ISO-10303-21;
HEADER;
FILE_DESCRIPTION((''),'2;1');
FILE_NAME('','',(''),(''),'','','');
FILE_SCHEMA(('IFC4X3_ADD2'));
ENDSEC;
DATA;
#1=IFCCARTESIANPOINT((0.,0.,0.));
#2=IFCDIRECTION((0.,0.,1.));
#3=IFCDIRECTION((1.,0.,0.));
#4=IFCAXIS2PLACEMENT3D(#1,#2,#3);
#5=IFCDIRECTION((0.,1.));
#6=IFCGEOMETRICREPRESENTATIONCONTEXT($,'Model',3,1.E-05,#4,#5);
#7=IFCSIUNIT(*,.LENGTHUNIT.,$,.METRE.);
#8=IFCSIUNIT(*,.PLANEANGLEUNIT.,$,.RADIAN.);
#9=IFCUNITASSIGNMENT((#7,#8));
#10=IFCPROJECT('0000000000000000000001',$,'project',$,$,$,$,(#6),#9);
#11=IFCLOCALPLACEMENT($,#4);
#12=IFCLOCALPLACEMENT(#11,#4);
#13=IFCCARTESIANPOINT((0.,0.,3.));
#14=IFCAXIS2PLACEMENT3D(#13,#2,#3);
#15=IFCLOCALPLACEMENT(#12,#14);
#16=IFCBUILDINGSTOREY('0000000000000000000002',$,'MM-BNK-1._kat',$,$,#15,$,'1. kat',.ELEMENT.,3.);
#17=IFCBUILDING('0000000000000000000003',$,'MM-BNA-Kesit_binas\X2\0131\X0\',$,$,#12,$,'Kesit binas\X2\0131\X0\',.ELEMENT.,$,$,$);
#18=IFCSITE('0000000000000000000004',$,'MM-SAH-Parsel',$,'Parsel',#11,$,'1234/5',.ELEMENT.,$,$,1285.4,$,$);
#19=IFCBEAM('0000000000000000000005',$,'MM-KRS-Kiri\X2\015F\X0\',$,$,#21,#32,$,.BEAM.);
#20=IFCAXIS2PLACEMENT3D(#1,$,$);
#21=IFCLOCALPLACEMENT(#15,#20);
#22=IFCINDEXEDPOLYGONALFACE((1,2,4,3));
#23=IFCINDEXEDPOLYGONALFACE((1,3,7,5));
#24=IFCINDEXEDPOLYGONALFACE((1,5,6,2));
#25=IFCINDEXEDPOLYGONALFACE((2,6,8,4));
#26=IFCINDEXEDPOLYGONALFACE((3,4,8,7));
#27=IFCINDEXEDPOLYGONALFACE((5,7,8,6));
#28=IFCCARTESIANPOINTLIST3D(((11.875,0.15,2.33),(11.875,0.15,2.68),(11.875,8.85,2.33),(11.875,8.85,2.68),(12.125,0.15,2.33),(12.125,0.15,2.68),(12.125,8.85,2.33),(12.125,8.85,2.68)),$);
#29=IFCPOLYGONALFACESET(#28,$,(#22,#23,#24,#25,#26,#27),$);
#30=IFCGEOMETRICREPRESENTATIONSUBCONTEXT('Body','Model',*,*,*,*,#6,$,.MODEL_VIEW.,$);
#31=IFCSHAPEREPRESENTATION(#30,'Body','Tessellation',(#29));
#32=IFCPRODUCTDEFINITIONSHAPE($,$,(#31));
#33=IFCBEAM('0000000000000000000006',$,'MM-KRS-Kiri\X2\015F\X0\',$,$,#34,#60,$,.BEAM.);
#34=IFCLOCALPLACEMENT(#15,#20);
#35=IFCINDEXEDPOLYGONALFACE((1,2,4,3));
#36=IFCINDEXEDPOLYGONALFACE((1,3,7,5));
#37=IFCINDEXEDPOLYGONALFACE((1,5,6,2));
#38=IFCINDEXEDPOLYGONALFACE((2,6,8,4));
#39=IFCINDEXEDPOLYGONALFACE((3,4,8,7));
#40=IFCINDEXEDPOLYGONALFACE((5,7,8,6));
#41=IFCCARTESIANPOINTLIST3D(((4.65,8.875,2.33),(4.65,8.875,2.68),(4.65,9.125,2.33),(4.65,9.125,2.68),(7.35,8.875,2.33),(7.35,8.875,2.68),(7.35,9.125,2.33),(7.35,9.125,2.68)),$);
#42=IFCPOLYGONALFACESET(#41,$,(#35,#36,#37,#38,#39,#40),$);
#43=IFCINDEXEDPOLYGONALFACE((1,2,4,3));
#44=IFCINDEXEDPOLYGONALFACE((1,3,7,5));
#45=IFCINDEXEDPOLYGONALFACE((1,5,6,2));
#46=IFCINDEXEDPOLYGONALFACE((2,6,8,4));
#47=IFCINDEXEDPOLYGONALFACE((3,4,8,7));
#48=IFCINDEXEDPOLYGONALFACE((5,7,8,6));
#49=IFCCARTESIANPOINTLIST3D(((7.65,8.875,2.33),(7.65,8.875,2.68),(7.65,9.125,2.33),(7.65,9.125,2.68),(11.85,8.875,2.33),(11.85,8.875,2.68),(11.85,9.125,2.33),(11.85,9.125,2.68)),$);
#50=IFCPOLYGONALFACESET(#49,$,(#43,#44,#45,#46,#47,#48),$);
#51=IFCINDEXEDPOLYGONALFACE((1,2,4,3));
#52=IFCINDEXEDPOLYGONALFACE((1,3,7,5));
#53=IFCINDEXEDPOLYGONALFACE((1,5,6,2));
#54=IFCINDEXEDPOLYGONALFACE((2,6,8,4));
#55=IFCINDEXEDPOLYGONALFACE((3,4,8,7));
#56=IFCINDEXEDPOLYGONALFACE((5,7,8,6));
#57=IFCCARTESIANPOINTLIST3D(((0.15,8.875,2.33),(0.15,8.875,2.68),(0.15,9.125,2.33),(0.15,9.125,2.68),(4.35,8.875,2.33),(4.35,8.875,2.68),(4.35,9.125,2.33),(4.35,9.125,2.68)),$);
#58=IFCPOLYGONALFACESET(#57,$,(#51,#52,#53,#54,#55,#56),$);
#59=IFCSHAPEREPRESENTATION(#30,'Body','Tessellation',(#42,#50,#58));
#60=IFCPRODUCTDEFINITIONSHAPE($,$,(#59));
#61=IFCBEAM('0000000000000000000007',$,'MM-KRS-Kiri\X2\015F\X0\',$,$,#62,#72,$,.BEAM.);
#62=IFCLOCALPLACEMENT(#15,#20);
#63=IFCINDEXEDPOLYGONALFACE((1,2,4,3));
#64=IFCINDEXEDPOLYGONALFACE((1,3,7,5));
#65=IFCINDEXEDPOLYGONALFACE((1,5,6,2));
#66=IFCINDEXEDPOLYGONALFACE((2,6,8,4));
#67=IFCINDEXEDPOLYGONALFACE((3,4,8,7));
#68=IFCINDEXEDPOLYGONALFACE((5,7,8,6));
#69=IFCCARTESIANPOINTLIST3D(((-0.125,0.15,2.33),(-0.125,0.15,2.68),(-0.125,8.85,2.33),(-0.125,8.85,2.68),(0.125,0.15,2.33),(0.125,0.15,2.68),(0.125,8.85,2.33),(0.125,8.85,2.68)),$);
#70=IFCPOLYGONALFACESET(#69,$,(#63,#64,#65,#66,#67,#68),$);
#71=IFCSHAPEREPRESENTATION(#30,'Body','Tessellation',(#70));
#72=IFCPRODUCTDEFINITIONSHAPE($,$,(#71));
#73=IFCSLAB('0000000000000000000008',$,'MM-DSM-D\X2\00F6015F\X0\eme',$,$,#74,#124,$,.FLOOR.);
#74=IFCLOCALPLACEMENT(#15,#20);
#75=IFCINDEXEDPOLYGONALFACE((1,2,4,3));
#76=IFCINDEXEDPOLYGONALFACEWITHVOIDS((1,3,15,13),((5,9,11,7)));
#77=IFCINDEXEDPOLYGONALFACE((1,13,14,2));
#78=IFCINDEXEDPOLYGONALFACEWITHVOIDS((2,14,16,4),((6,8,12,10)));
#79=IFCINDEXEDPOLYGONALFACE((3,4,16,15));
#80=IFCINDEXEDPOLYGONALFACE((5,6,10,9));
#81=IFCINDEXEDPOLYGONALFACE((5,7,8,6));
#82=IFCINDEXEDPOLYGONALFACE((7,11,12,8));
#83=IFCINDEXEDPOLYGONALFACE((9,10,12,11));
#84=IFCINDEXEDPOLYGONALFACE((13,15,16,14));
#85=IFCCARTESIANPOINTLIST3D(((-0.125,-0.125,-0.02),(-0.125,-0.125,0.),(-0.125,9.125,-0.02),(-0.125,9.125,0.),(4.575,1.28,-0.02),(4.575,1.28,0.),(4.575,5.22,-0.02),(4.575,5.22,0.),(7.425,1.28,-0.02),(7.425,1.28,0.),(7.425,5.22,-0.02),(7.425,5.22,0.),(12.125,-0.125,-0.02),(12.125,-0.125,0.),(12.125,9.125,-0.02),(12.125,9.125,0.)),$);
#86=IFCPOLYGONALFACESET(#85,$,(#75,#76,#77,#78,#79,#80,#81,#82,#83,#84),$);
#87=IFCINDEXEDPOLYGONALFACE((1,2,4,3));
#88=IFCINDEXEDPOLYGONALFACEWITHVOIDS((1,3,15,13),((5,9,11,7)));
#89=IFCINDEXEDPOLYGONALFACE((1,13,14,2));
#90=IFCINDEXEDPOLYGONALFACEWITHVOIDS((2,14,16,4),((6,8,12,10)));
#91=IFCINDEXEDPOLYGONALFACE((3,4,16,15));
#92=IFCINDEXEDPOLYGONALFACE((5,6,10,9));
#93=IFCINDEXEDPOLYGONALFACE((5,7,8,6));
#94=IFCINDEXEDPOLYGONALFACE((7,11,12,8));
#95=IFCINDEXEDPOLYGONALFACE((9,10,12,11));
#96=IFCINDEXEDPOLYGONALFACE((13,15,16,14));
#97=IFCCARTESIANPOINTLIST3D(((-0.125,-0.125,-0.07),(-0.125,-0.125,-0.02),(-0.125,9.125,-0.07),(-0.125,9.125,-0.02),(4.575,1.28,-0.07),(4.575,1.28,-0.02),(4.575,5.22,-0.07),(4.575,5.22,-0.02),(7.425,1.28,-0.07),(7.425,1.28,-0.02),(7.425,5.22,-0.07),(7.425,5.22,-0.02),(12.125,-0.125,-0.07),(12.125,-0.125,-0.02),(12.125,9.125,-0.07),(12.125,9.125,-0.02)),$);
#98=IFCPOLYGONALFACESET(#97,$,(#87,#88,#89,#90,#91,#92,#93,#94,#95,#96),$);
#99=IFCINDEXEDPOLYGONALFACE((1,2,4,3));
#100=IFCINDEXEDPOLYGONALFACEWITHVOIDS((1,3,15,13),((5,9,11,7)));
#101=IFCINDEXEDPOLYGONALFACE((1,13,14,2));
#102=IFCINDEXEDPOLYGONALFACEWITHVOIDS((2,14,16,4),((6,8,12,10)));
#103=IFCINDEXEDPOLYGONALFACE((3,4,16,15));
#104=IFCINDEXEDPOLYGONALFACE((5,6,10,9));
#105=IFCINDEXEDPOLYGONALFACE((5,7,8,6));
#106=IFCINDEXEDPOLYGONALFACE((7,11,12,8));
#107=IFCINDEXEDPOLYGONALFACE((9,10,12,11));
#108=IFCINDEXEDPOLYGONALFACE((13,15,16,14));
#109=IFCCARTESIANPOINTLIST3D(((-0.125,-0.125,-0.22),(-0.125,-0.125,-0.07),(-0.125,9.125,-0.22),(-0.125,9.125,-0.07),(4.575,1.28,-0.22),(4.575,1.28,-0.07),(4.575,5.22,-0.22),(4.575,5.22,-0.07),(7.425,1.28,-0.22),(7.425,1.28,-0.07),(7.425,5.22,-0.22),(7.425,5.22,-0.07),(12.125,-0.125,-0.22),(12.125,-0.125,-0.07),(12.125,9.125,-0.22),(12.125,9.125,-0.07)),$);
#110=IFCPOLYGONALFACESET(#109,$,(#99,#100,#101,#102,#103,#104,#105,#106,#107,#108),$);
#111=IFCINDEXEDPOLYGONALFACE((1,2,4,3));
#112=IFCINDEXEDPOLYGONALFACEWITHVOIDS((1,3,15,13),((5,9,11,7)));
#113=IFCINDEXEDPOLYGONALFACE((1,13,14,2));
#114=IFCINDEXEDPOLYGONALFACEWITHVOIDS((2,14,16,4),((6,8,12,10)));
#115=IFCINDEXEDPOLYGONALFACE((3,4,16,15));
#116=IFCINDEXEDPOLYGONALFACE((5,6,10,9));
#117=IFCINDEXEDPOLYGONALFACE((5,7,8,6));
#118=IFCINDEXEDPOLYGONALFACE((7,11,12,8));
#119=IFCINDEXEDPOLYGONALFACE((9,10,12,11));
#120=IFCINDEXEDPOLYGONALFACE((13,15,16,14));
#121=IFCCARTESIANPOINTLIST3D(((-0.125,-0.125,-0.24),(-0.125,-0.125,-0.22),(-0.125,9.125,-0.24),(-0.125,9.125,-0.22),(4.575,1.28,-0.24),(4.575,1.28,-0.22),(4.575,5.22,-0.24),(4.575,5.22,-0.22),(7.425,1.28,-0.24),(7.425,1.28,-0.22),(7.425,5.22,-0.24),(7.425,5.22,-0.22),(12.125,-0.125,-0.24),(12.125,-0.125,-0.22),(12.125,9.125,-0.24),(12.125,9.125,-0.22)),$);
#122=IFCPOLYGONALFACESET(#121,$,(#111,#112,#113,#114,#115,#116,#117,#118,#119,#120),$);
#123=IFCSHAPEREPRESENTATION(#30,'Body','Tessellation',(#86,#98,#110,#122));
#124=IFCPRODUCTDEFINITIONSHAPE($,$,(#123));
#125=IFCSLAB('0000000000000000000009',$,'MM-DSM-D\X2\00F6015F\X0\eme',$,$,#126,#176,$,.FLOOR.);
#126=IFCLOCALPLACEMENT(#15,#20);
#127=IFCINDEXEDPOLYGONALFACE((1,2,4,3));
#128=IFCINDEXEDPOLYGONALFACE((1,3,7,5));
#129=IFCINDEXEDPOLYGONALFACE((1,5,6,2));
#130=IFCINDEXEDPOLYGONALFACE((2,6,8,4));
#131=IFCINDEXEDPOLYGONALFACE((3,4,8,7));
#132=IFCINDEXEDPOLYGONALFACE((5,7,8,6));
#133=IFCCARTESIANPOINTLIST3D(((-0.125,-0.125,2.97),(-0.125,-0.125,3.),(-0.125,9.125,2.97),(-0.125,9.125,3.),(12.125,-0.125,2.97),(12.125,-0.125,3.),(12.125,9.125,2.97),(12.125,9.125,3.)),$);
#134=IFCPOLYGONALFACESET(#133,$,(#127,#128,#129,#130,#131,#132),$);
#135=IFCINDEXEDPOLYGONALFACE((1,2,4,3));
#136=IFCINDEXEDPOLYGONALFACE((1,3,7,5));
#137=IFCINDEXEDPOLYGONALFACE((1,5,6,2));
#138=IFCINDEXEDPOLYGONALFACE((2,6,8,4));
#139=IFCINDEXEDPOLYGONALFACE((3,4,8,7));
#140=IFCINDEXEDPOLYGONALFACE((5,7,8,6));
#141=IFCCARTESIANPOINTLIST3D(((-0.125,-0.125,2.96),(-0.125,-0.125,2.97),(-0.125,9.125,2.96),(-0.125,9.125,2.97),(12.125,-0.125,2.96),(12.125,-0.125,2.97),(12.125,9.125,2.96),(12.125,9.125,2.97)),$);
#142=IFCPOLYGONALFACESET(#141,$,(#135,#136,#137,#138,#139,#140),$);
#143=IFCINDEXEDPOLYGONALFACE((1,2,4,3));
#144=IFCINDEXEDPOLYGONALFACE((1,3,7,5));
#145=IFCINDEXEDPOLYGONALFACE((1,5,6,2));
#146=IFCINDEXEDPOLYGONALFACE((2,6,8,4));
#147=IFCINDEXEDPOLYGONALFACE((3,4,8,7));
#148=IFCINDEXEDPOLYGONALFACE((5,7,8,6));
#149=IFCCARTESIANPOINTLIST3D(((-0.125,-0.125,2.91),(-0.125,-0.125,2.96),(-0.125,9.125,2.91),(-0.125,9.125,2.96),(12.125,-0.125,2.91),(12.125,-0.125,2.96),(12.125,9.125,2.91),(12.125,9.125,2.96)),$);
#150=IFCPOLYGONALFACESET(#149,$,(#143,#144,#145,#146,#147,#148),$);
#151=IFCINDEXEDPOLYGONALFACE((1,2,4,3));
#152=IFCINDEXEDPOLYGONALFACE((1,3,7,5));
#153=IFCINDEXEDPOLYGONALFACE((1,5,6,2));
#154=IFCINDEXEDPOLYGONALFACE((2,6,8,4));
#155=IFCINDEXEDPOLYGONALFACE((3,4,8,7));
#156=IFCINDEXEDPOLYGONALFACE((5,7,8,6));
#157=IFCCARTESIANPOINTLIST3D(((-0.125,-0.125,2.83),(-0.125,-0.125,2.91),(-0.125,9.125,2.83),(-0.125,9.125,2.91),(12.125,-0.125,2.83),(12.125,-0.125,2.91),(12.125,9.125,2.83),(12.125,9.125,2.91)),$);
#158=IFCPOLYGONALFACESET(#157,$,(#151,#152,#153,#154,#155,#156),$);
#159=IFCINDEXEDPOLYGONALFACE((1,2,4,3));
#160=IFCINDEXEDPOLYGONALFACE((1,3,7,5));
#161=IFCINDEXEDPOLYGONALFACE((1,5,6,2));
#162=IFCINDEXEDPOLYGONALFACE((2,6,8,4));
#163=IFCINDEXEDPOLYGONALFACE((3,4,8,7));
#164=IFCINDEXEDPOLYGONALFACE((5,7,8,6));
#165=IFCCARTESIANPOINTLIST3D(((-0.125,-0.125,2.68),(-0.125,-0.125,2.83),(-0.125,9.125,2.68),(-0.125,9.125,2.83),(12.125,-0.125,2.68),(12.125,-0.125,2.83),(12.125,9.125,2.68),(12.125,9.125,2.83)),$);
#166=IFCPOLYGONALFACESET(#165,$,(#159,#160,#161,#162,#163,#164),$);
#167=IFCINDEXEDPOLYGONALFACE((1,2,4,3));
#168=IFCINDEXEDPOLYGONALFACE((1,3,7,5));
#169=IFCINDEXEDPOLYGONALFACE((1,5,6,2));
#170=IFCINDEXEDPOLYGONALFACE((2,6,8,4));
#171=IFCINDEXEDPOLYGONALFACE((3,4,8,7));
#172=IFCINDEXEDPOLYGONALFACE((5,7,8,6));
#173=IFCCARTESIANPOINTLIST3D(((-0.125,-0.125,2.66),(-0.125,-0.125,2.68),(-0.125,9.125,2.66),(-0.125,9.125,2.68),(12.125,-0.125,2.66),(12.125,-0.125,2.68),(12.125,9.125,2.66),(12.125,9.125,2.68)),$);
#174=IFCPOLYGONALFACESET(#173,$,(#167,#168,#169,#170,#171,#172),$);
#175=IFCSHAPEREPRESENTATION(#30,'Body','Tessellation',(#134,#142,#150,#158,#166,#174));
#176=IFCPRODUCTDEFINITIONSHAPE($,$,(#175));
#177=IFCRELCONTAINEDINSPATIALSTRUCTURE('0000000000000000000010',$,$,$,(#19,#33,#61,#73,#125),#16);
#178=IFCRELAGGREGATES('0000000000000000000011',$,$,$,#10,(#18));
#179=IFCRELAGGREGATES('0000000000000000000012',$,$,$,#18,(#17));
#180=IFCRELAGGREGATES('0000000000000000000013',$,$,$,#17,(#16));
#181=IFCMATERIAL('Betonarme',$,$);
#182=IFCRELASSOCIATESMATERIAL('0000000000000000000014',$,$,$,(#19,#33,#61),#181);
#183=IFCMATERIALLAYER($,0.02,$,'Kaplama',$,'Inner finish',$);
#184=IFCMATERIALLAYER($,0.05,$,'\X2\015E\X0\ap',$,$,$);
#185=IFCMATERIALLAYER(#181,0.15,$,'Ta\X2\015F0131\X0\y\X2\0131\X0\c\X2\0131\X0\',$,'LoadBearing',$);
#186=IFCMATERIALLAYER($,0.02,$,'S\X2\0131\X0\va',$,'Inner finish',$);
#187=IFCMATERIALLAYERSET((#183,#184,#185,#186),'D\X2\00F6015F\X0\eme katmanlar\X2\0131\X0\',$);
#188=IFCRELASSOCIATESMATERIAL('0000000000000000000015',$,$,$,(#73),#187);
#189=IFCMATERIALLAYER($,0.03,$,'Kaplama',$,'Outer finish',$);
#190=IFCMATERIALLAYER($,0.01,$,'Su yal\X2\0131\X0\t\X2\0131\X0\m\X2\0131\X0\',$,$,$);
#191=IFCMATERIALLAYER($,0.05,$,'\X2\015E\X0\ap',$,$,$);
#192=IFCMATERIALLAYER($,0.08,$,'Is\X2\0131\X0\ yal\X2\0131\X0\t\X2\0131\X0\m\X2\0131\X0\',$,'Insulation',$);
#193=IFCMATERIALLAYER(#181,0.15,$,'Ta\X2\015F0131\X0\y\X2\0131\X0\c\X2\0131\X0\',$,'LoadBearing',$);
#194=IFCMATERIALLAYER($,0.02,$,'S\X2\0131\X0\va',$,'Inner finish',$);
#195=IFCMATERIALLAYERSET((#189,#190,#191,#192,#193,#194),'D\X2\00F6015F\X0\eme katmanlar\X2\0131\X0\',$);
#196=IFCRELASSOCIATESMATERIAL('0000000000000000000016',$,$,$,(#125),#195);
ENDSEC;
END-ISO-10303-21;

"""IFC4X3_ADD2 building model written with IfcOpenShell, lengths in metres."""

from ifc_helpers import new_model, si_unit, direction, frame, origin_with_axes, place, context, subcontext, project, spatial, polyline, outline, extrude, material, layer, layer_set, layer_usage, element, save


model = new_model("IFC4X3_ADD2")

# Units and contexts
model_context = context("Model", 3, precision=1e-05, world=origin_with_axes(), true_north=direction((0.0, 1.0)))
body_context = subcontext(model_context, "Body", "Model", "MODEL_VIEW")
ifc_project = project(units=[si_unit("LENGTHUNIT", "METRE"), si_unit("PLANEANGLEUNIT", "RADIAN")], contexts=[model_context])

# Site, building, storey
site_placement = place(None, origin_with_axes())
site = spatial("IfcSite", under=ifc_project, at=site_placement, Name="MM-SAH-Parsel", ObjectType="Parsel", LongName="1234/5", CompositionType="ELEMENT", RefElevation=1285.4)
building_placement = place(site_placement, origin_with_axes())
building = spatial("IfcBuilding", under=site, at=building_placement, Name="MM-BNA-Kesit_binası", LongName="Kesit binası", CompositionType="ELEMENT")
storey_placement = place(building_placement, frame((0.0, 0.0, 3.0), z_axis=(0.0, 0.0, 1.0), x_axis=(1.0, 0.0, 0.0)))
storey = spatial("IfcBuildingStorey", under=building, at=storey_placement, Name="MM-BNK-1._kat", LongName="1. kat", CompositionType="ELEMENT", Elevation=3.0)

# Shared definitions
ifc_material_1 = material(Name="Betonarme")

# Beams
beam_1_placement = place(storey_placement, origin_with_axes())
element("IfcBeam", 1, at=beam_1_placement, inside=storey, material=ifc_material_1, Name="MM-KRS-Kiriş", PredefinedType="BEAM", context=body_context, shape_type="SweptSolid", body=[
    extrude(outline(polyline([(12.125, 0.15), (12.125, 8.85), (11.875, 8.85), (11.875, 0.15), (12.125, 0.15)])), frame((0.0, 0.0, 2.33)), (0.0, 0.0, 1.0), 0.35),
])
beam_2_placement = place(storey_placement, origin_with_axes())
element("IfcBeam", 2, at=beam_2_placement, inside=storey, material=ifc_material_1, Name="MM-KRS-Kiriş", PredefinedType="BEAM", context=body_context, shape_type="SweptSolid", body=[
    extrude(outline(polyline([(7.35, 9.125), (4.65, 9.125), (4.65, 8.875), (7.35, 8.875), (7.35, 9.125)])), frame((0.0, 0.0, 2.33)), (0.0, 0.0, 1.0), 0.35),
    extrude(outline(polyline([(11.85, 9.125), (7.65, 9.125), (7.65, 8.875), (11.85, 8.875), (11.85, 9.125)])), frame((0.0, 0.0, 2.33)), (0.0, 0.0, 1.0), 0.35),
    extrude(outline(polyline([(4.35, 9.125), (0.15, 9.125), (0.15, 8.875), (4.35, 8.875), (4.35, 9.125)])), frame((0.0, 0.0, 2.33)), (0.0, 0.0, 1.0), 0.35),
])
beam_3_placement = place(storey_placement, origin_with_axes())
element("IfcBeam", 3, at=beam_3_placement, inside=storey, material=ifc_material_1, Name="MM-KRS-Kiriş", PredefinedType="BEAM", context=body_context, shape_type="SweptSolid", body=[
    extrude(outline(polyline([(-0.125, 8.85), (-0.125, 0.15), (0.125, 0.15), (0.125, 8.85), (-0.125, 8.85)])), frame((0.0, 0.0, 2.33)), (0.0, 0.0, 1.0), 0.35),
])

# Slab, opening
ifc_layer_1 = layer(None, 0.02, Name="Kaplama", Category="Inner finish")
ifc_layer_2 = layer(None, 0.05, Name="Şap")
ifc_layer_3 = layer(ifc_material_1, 0.15, Name="Taşıyıcı", Category="LoadBearing")
ifc_layer_4 = layer(None, 0.02, Name="Sıva", Category="Inner finish")
ifc_layer_set_1 = layer_set([ifc_layer_1, ifc_layer_2, ifc_layer_3, ifc_layer_4], Name="Döşeme katmanları")
ifc_layer_usage_1 = layer_usage(ifc_layer_set_1, "AXIS3", "NEGATIVE", 0.0)
slab_1_placement = place(storey_placement, origin_with_axes())
slab_1 = element("IfcSlab", 4, at=slab_1_placement, inside=storey, material=ifc_layer_usage_1, Name="MM-DSM-Döşeme", PredefinedType="FLOOR", context=body_context, shape_type="SweptSolid", body=[
    extrude(outline(polyline([(-0.125, -0.125), (12.125, -0.125), (12.125, 9.125), (-0.125, 9.125), (-0.125, -0.125)])), frame((0.0, 0.0, -0.02)), (0.0, 0.0, 1.0), 0.02),
    extrude(outline(polyline([(-0.125, -0.125), (12.125, -0.125), (12.125, 9.125), (-0.125, 9.125), (-0.125, -0.125)])), frame((0.0, 0.0, -0.07)), (0.0, 0.0, 1.0), 0.05),
    extrude(outline(polyline([(-0.125, -0.125), (12.125, -0.125), (12.125, 9.125), (-0.125, 9.125), (-0.125, -0.125)])), frame((0.0, 0.0, -0.22)), (0.0, 0.0, 1.0), 0.15),
    extrude(outline(polyline([(-0.125, -0.125), (12.125, -0.125), (12.125, 9.125), (-0.125, 9.125), (-0.125, -0.125)])), frame((0.0, 0.0, -0.24)), (0.0, 0.0, 1.0), 0.02),
])
opening_1_placement = place(storey_placement, origin_with_axes())
element("IfcOpeningElement", 5, at=opening_1_placement, cuts=slab_1, PredefinedType="OPENING", context=body_context, shape_type="SweptSolid", body=[
    extrude(outline(polyline([(4.575, 1.28), (4.575, 5.22), (7.425, 5.22), (7.425, 1.28), (4.575, 1.28)])), frame((0.0, 0.0, -0.24)), (0.0, 0.0, 1.0), 0.24),
])

# Slab
ifc_layer_5 = layer(None, 0.03, Name="Kaplama", Category="Outer finish")
ifc_layer_6 = layer(None, 0.01, Name="Su yalıtımı")
ifc_layer_7 = layer(None, 0.05, Name="Şap")
ifc_layer_8 = layer(None, 0.08, Name="Isı yalıtımı", Category="Insulation")
ifc_layer_9 = layer(ifc_material_1, 0.15, Name="Taşıyıcı", Category="LoadBearing")
ifc_layer_10 = layer(None, 0.02, Name="Sıva", Category="Inner finish")
ifc_layer_set_2 = layer_set([ifc_layer_5, ifc_layer_6, ifc_layer_7, ifc_layer_8, ifc_layer_9, ifc_layer_10], Name="Döşeme katmanları")
ifc_layer_usage_2 = layer_usage(ifc_layer_set_2, "AXIS3", "NEGATIVE", 3.0)
slab_2_placement = place(storey_placement, origin_with_axes())
element("IfcSlab", 6, at=slab_2_placement, inside=storey, material=ifc_layer_usage_2, Name="MM-DSM-Döşeme", PredefinedType="FLOOR", context=body_context, shape_type="SweptSolid", body=[
    extrude(outline(polyline([(-0.125, -0.125), (12.125, -0.125), (12.125, 9.125), (-0.125, 9.125), (-0.125, -0.125)])), frame((0.0, 0.0, 2.97)), (0.0, 0.0, 1.0), 0.03),
    extrude(outline(polyline([(-0.125, -0.125), (12.125, -0.125), (12.125, 9.125), (-0.125, 9.125), (-0.125, -0.125)])), frame((0.0, 0.0, 2.96)), (0.0, 0.0, 1.0), 0.01),
    extrude(outline(polyline([(-0.125, -0.125), (12.125, -0.125), (12.125, 9.125), (-0.125, 9.125), (-0.125, -0.125)])), frame((0.0, 0.0, 2.91)), (0.0, 0.0, 1.0), 0.05),
    extrude(outline(polyline([(-0.125, -0.125), (12.125, -0.125), (12.125, 9.125), (-0.125, 9.125), (-0.125, -0.125)])), frame((0.0, 0.0, 2.83)), (0.0, 0.0, 1.0), 0.08),
    extrude(outline(polyline([(-0.125, -0.125), (12.125, -0.125), (12.125, 9.125), (-0.125, 9.125), (-0.125, -0.125)])), frame((0.0, 0.0, 2.68)), (0.0, 0.0, 1.0), 0.15),
    extrude(outline(polyline([(-0.125, -0.125), (12.125, -0.125), (12.125, 9.125), (-0.125, 9.125), (-0.125, -0.125)])), frame((0.0, 0.0, 2.66)), (0.0, 0.0, 1.0), 0.02),
])

save(model, "model.ifc")
